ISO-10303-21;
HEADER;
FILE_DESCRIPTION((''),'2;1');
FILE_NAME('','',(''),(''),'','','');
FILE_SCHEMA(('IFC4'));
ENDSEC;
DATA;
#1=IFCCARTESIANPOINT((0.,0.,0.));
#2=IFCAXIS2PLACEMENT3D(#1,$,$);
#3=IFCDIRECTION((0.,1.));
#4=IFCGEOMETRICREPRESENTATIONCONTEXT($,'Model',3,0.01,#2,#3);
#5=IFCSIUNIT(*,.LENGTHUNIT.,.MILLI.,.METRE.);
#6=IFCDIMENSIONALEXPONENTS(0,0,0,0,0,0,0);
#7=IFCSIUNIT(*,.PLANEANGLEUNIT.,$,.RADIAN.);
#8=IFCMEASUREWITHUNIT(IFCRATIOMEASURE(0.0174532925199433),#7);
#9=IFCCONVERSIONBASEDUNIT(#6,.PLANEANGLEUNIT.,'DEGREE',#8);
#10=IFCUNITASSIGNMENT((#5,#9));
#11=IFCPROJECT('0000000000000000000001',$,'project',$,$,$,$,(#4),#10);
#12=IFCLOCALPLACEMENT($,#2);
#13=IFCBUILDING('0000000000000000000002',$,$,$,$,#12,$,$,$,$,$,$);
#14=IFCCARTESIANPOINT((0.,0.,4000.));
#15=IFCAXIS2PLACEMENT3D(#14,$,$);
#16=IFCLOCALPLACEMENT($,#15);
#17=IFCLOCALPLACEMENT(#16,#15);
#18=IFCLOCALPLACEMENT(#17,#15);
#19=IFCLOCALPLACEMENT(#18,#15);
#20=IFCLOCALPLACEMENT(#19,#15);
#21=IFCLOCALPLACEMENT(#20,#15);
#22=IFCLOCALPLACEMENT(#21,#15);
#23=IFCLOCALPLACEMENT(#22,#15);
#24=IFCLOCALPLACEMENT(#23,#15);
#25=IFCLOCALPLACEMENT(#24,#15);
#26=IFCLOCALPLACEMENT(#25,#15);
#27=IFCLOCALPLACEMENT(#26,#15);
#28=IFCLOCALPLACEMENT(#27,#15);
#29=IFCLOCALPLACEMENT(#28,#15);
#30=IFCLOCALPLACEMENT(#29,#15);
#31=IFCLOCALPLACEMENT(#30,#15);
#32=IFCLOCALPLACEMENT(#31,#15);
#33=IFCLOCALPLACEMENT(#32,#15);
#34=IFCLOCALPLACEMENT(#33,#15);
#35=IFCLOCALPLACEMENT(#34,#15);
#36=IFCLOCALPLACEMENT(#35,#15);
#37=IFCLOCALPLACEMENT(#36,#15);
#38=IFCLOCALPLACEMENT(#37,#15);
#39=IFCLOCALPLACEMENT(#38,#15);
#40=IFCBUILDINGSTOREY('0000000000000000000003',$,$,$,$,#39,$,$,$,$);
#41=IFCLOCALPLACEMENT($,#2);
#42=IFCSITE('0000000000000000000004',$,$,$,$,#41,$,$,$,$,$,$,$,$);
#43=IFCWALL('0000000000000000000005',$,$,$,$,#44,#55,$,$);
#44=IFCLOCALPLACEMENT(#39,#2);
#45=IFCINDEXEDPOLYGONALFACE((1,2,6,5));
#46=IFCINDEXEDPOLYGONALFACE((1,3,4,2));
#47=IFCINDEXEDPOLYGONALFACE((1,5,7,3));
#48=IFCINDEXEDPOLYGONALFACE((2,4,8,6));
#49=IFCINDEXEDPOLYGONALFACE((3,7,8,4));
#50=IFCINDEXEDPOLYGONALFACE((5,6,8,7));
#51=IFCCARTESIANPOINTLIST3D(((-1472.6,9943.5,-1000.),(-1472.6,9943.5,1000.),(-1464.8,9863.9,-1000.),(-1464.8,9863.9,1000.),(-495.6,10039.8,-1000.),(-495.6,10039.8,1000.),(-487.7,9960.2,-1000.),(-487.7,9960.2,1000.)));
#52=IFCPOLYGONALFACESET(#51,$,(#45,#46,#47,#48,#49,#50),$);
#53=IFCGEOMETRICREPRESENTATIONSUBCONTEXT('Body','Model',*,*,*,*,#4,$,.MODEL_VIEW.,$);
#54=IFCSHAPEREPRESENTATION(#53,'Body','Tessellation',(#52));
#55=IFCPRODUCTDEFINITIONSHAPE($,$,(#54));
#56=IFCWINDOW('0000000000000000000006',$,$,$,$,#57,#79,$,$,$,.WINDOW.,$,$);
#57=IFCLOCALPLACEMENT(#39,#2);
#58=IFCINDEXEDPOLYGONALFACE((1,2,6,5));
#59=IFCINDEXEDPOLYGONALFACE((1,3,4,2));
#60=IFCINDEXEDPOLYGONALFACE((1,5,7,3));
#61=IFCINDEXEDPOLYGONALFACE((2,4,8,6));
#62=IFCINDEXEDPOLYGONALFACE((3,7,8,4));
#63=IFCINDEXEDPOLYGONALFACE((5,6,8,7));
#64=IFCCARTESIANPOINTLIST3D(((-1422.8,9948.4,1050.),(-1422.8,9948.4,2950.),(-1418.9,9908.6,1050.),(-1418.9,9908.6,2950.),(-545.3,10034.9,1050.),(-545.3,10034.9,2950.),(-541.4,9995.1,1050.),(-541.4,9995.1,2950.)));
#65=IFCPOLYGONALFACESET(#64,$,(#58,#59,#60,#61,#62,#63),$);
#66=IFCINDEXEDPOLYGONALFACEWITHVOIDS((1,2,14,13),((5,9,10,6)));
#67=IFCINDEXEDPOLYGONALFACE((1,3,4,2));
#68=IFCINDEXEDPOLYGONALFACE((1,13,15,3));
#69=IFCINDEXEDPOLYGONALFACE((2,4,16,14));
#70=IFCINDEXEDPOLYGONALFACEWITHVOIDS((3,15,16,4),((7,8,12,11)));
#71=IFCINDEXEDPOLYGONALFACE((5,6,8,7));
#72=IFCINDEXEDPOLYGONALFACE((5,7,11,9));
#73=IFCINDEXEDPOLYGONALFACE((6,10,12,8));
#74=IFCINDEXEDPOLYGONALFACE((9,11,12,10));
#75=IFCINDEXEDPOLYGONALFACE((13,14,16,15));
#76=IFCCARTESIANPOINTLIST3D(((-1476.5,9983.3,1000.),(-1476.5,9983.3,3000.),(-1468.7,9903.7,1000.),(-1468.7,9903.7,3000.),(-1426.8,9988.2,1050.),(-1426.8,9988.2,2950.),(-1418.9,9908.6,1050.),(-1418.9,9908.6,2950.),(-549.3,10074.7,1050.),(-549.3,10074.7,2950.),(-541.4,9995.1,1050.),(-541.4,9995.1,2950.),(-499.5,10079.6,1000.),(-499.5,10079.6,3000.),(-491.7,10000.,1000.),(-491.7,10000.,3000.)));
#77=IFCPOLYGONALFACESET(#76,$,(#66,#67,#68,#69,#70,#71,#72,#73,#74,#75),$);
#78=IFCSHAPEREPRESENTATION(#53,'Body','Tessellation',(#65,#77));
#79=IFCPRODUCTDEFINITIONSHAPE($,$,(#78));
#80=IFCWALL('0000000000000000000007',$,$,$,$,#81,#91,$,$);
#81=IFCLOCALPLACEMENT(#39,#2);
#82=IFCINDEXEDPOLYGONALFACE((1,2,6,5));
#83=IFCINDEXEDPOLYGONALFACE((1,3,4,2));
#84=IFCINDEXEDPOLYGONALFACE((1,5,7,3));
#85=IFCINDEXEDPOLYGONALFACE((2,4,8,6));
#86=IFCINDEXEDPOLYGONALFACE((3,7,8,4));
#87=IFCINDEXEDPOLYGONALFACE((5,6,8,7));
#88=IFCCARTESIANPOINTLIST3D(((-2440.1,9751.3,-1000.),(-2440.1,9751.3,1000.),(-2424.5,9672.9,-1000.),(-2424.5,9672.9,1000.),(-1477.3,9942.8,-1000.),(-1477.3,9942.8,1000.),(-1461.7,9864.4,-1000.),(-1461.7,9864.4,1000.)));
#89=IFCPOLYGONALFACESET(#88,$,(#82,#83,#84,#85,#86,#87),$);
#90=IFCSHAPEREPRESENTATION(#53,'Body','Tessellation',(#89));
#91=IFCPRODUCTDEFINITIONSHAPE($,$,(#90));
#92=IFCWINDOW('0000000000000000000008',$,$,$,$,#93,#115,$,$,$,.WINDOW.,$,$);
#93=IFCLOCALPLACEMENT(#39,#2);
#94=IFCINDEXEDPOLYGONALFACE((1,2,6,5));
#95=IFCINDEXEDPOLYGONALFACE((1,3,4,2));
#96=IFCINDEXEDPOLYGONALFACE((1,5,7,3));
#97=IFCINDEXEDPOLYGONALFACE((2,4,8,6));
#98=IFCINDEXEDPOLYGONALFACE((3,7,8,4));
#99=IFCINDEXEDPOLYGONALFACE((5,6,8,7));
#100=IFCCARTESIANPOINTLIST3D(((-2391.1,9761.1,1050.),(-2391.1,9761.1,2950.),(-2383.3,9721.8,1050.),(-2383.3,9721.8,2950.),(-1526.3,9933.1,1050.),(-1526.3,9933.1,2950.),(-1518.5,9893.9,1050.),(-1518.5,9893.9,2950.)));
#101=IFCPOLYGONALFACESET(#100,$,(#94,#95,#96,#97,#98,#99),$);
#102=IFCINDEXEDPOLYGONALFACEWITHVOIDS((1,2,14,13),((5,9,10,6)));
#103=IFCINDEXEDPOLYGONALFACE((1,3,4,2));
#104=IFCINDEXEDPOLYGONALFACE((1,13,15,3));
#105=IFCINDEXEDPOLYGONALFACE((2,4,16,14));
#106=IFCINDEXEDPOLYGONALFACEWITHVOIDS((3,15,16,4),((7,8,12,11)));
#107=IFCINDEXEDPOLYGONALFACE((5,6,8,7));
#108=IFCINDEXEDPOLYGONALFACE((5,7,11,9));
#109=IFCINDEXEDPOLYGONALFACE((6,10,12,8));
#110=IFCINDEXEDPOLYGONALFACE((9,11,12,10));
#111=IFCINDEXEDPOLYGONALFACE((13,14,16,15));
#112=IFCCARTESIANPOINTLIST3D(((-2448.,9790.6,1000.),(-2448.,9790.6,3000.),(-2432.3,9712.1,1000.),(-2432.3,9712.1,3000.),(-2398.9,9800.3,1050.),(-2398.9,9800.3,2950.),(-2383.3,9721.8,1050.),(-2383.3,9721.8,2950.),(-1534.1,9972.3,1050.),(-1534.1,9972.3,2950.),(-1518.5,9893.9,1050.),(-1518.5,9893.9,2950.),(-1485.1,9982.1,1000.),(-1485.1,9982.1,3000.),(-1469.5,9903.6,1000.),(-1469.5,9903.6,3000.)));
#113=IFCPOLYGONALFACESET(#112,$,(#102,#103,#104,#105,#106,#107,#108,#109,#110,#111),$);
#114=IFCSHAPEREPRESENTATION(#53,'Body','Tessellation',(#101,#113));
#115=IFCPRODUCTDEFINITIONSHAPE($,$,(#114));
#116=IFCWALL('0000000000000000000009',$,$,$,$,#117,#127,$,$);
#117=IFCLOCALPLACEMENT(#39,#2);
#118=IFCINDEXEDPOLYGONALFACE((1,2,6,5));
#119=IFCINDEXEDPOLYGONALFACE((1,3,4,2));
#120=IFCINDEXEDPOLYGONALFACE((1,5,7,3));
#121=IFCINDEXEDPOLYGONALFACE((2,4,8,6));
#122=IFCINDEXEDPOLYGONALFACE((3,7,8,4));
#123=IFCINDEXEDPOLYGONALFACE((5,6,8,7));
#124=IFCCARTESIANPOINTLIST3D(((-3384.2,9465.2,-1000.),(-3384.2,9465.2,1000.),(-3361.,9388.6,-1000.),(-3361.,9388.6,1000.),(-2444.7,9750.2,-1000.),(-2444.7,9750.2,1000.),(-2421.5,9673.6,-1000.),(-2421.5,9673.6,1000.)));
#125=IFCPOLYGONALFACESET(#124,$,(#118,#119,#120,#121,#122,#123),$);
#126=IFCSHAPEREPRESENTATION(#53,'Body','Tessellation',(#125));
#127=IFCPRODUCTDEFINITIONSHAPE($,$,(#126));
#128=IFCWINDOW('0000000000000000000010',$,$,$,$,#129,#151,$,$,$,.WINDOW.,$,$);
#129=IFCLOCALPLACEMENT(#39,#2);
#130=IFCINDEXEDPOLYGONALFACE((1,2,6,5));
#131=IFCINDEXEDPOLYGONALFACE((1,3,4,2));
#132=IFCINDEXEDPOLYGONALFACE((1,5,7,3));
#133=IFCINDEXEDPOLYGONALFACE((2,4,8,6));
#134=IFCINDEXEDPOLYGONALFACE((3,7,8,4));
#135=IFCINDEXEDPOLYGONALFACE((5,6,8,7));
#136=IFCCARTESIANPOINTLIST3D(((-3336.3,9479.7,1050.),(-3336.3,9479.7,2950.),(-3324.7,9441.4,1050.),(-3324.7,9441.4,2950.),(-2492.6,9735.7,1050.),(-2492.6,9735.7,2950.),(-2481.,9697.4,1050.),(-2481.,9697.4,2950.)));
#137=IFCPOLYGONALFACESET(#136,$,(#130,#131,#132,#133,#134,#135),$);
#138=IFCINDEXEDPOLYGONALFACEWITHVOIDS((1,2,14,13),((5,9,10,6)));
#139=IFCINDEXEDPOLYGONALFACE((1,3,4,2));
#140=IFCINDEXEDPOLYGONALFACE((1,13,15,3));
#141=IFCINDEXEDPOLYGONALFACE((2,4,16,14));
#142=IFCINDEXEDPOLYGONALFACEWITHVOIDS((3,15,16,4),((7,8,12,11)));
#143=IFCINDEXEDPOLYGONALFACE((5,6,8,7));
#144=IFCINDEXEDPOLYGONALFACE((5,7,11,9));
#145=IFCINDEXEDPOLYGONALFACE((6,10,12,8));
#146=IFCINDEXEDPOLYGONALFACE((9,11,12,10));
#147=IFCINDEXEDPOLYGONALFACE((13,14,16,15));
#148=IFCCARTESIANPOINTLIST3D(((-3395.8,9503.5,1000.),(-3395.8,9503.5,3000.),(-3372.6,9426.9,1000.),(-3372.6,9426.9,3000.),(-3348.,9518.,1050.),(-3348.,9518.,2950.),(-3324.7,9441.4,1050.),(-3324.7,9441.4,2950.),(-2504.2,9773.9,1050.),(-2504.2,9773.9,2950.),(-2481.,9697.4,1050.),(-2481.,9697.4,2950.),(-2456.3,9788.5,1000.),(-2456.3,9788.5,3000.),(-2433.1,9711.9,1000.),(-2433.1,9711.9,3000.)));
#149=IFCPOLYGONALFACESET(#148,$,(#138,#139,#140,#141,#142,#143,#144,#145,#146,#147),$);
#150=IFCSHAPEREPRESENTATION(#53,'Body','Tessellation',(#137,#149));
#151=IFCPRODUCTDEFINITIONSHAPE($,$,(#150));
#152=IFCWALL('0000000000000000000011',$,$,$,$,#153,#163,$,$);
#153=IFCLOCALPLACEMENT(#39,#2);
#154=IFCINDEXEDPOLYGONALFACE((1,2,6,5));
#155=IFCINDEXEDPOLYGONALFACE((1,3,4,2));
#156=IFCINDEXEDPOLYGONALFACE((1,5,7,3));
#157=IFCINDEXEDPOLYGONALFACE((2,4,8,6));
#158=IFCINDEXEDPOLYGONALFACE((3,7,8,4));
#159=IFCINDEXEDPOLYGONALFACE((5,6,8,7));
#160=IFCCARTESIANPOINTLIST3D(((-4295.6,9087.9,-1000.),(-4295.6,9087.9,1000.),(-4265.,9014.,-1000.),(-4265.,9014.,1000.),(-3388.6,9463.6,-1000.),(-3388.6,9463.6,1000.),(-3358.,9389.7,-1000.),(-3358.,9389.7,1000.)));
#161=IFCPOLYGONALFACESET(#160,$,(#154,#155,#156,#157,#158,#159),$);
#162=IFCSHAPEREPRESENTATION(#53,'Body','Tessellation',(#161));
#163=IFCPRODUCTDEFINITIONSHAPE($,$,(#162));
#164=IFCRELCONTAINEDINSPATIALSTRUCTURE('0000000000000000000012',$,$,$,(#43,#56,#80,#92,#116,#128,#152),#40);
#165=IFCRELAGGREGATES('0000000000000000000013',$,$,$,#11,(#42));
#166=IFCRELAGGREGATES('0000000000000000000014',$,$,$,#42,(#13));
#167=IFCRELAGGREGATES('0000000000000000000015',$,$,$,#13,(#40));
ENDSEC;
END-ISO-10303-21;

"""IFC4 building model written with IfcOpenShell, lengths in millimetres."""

from ifc_helpers import new_model, entity, si_unit, converted_unit, direction, frame, origin, origin_2d, place, context, subcontext, project, spatial, rectangle, extrude, element, save


model = new_model("IFC4")

# Units and contexts
model_context = context("Model", 3, precision=0.01, world=origin(), true_north=direction((0.0, 1.0)))
body_context = subcontext(model_context, "Body", "Model", "MODEL_VIEW")
ifc_project = project(units=[si_unit("LENGTHUNIT", "METRE", prefix="MILLI"), converted_unit("PLANEANGLEUNIT", "DEGREE", entity("IfcRatioMeasure", 0.0174532925199433), si_unit("PLANEANGLEUNIT", "RADIAN"), dimensions=[0, 0, 0, 0, 0, 0, 0])], contexts=[model_context])

# Site, building, storey
site_placement = place(None, origin())
site = spatial("IfcSite", under=ifc_project, at=site_placement)
building_placement = place(None, origin())
building = spatial("IfcBuilding", under=site, at=building_placement)
placement_1 = place(None, frame((0.0, 0.0, 4000.0)))
placement_2 = place(placement_1, frame((0.0, 0.0, 4000.0)))
placement_3 = place(placement_2, frame((0.0, 0.0, 4000.0)))
placement_4 = place(placement_3, frame((0.0, 0.0, 4000.0)))
placement_5 = place(placement_4, frame((0.0, 0.0, 4000.0)))
placement_6 = place(placement_5, frame((0.0, 0.0, 4000.0)))
placement_7 = place(placement_6, frame((0.0, 0.0, 4000.0)))
placement_8 = place(placement_7, frame((0.0, 0.0, 4000.0)))
placement_9 = place(placement_8, frame((0.0, 0.0, 4000.0)))
placement_10 = place(placement_9, frame((0.0, 0.0, 4000.0)))
placement_11 = place(placement_10, frame((0.0, 0.0, 4000.0)))
placement_12 = place(placement_11, frame((0.0, 0.0, 4000.0)))
placement_13 = place(placement_12, frame((0.0, 0.0, 4000.0)))
placement_14 = place(placement_13, frame((0.0, 0.0, 4000.0)))
placement_15 = place(placement_14, frame((0.0, 0.0, 4000.0)))
placement_16 = place(placement_15, frame((0.0, 0.0, 4000.0)))
placement_17 = place(placement_16, frame((0.0, 0.0, 4000.0)))
placement_18 = place(placement_17, frame((0.0, 0.0, 4000.0)))
placement_19 = place(placement_18, frame((0.0, 0.0, 4000.0)))
placement_20 = place(placement_19, frame((0.0, 0.0, 4000.0)))
placement_21 = place(placement_20, frame((0.0, 0.0, 4000.0)))
placement_22 = place(placement_21, frame((0.0, 0.0, 4000.0)))
placement_23 = place(placement_22, frame((0.0, 0.0, 4000.0)))
storey_placement = place(placement_23, frame((0.0, 0.0, 4000.0)))
storey = spatial("IfcBuildingStorey", under=building, at=storey_placement)

# Shared definitions
cartesian_point_1 = entity("IfcCartesianPoint", [-440.9, -950.0])
shared_polyline = entity("IfcPolyline", [cartesian_point_1, entity("IfcCartesianPoint", [-440.9, 950.0]), entity("IfcCartesianPoint", [-440.9, 950.0]), entity("IfcCartesianPoint", [440.9, 950.0]), entity("IfcCartesianPoint", [440.9, 950.0]), entity("IfcCartesianPoint", [440.9, -950.0]), entity("IfcCartesianPoint", [440.9, -950.0]), entity("IfcCartesianPoint", [-440.9, -950.0]), cartesian_point_1])

# Wall
wall_1_placement = place(storey_placement, frame((-980.2, 9951.8, -1000.0), z_axis=(0.0, 0.0, 1.0), x_axis=(-9951.847302, -980.17105, 0.0)))
element("IfcWall", 1, at=wall_1_placement, inside=storey, context=body_context, shape_type="SweptSolid", body=[
    extrude(rectangle(XDim=981.7, YDim=80.0, at=origin_2d()), origin(), (0.0, 0.0, 1.0), 2000.0),
])

# Window
window_1_placement = place(storey_placement, frame((-980.2, 9951.8, 2000.0), z_axis=(0.0, 0.0, 1.0), x_axis=(-9951.847302, -980.17105, 0.0)))
cartesian_point_2 = entity("IfcCartesianPoint", [-490.9, -1000.0])
element("IfcWindow", 2, at=window_1_placement, inside=storey, PredefinedType="WINDOW", context=body_context, shape_type="SweptSolid", body=[
    entity("IfcExtrudedAreaSolid", entity("IfcArbitraryClosedProfileDef", "AREA", None, shared_polyline), entity("IfcAxis2Placement3D", entity("IfcCartesianPoint", [0.0, 0.0, 0.0]), entity("IfcDirection", [0.0, -1.0, 0.0]), entity("IfcDirection", [1.0, 0.0, 0.0])), entity("IfcDirection", [0.0, 0.0, 1.0]), 40.0),
    entity("IfcExtrudedAreaSolid", entity("IfcArbitraryProfileDefWithVoids", "AREA", None, entity("IfcPolyline", [cartesian_point_2, entity("IfcCartesianPoint", [-490.9, 1000.0]), entity("IfcCartesianPoint", [-490.9, 1000.0]), entity("IfcCartesianPoint", [490.9, 1000.0]), entity("IfcCartesianPoint", [490.9, 1000.0]), entity("IfcCartesianPoint", [490.9, -1000.0]), entity("IfcCartesianPoint", [490.9, -1000.0]), entity("IfcCartesianPoint", [-490.9, -1000.0]), cartesian_point_2]), [shared_polyline]), entity("IfcAxis2Placement3D", entity("IfcCartesianPoint", [0.0, 0.0, 0.0]), entity("IfcDirection", [0.0, -1.0, 0.0]), entity("IfcDirection", [1.0, 0.0, 0.0])), entity("IfcDirection", [0.0, 0.0, 1.0]), 80.0),
])

# Wall
wall_2_placement = place(storey_placement, frame((-1950.9, 9807.9, -1000.0), z_axis=(0.0, 0.0, 1.0), x_axis=(-9807.852795, -1950.903264, 0.0)))
element("IfcWall", 3, at=wall_2_placement, inside=storey, context=body_context, shape_type="SweptSolid", body=[
    extrude(rectangle(XDim=981.7, YDim=80.0, at=origin_2d()), origin(), (0.0, 0.0, 1.0), 2000.0),
])

# Window
window_2_placement = place(storey_placement, frame((-1950.9, 9807.9, 2000.0), z_axis=(0.0, 0.0, 1.0), x_axis=(-9807.852795, -1950.903264, 0.0)))
cartesian_point_3 = entity("IfcCartesianPoint", [-490.9, -1000.0])
element("IfcWindow", 4, at=window_2_placement, inside=storey, PredefinedType="WINDOW", context=body_context, shape_type="SweptSolid", body=[
    entity("IfcExtrudedAreaSolid", entity("IfcArbitraryClosedProfileDef", "AREA", None, shared_polyline), entity("IfcAxis2Placement3D", entity("IfcCartesianPoint", [0.0, 0.0, 0.0]), entity("IfcDirection", [0.0, -1.0, 0.0]), entity("IfcDirection", [1.0, 0.0, 0.0])), entity("IfcDirection", [0.0, 0.0, 1.0]), 40.0),
    entity("IfcExtrudedAreaSolid", entity("IfcArbitraryProfileDefWithVoids", "AREA", None, entity("IfcPolyline", [cartesian_point_3, entity("IfcCartesianPoint", [-490.9, 1000.0]), entity("IfcCartesianPoint", [-490.9, 1000.0]), entity("IfcCartesianPoint", [490.9, 1000.0]), entity("IfcCartesianPoint", [490.9, 1000.0]), entity("IfcCartesianPoint", [490.9, -1000.0]), entity("IfcCartesianPoint", [490.9, -1000.0]), entity("IfcCartesianPoint", [-490.9, -1000.0]), cartesian_point_3]), [shared_polyline]), entity("IfcAxis2Placement3D", entity("IfcCartesianPoint", [0.0, 0.0, 0.0]), entity("IfcDirection", [0.0, -1.0, 0.0]), entity("IfcDirection", [1.0, 0.0, 0.0])), entity("IfcDirection", [0.0, 0.0, 1.0]), 80.0),
])

# Wall
wall_3_placement = place(storey_placement, frame((-2902.8, 9569.4, -1000.0), z_axis=(0.0, 0.0, 1.0), x_axis=(-9569.403228, -2902.847198, 0.0)))
element("IfcWall", 5, at=wall_3_placement, inside=storey, context=body_context, shape_type="SweptSolid", body=[
    extrude(rectangle(XDim=981.7, YDim=80.0, at=origin_2d()), origin(), (0.0, 0.0, 1.0), 2000.0),
])

# Window
window_3_placement = place(storey_placement, frame((-2902.8, 9569.4, 2000.0), z_axis=(0.0, 0.0, 1.0), x_axis=(-9569.403228, -2902.847198, 0.0)))
cartesian_point_4 = entity("IfcCartesianPoint", [-490.9, -1000.0])
element("IfcWindow", 6, at=window_3_placement, inside=storey, PredefinedType="WINDOW", context=body_context, shape_type="SweptSolid", body=[
    entity("IfcExtrudedAreaSolid", entity("IfcArbitraryClosedProfileDef", "AREA", None, shared_polyline), entity("IfcAxis2Placement3D", entity("IfcCartesianPoint", [0.0, 0.0, 0.0]), entity("IfcDirection", [0.0, -1.0, 0.0]), entity("IfcDirection", [1.0, 0.0, 0.0])), entity("IfcDirection", [0.0, 0.0, 1.0]), 40.0),
    entity("IfcExtrudedAreaSolid", entity("IfcArbitraryProfileDefWithVoids", "AREA", None, entity("IfcPolyline", [cartesian_point_4, entity("IfcCartesianPoint", [-490.9, 1000.0]), entity("IfcCartesianPoint", [-490.9, 1000.0]), entity("IfcCartesianPoint", [490.9, 1000.0]), entity("IfcCartesianPoint", [490.9, 1000.0]), entity("IfcCartesianPoint", [490.9, -1000.0]), entity("IfcCartesianPoint", [490.9, -1000.0]), entity("IfcCartesianPoint", [-490.9, -1000.0]), cartesian_point_4]), [shared_polyline]), entity("IfcAxis2Placement3D", entity("IfcCartesianPoint", [0.0, 0.0, 0.0]), entity("IfcDirection", [0.0, -1.0, 0.0]), entity("IfcDirection", [1.0, 0.0, 0.0])), entity("IfcDirection", [0.0, 0.0, 1.0]), 80.0),
])

# Wall
wall_4_placement = place(storey_placement, frame((-3826.8, 9238.8, -1000.0), z_axis=(0.0, 0.0, 1.0), x_axis=(-9238.795458, -3826.834002, 0.0)))
element("IfcWall", 7, at=wall_4_placement, inside=storey, context=body_context, shape_type="SweptSolid", body=[
    extrude(rectangle(XDim=981.7, YDim=80.0, at=origin_2d()), origin(), (0.0, 0.0, 1.0), 2000.0),
])

save(model, "model.ifc")
